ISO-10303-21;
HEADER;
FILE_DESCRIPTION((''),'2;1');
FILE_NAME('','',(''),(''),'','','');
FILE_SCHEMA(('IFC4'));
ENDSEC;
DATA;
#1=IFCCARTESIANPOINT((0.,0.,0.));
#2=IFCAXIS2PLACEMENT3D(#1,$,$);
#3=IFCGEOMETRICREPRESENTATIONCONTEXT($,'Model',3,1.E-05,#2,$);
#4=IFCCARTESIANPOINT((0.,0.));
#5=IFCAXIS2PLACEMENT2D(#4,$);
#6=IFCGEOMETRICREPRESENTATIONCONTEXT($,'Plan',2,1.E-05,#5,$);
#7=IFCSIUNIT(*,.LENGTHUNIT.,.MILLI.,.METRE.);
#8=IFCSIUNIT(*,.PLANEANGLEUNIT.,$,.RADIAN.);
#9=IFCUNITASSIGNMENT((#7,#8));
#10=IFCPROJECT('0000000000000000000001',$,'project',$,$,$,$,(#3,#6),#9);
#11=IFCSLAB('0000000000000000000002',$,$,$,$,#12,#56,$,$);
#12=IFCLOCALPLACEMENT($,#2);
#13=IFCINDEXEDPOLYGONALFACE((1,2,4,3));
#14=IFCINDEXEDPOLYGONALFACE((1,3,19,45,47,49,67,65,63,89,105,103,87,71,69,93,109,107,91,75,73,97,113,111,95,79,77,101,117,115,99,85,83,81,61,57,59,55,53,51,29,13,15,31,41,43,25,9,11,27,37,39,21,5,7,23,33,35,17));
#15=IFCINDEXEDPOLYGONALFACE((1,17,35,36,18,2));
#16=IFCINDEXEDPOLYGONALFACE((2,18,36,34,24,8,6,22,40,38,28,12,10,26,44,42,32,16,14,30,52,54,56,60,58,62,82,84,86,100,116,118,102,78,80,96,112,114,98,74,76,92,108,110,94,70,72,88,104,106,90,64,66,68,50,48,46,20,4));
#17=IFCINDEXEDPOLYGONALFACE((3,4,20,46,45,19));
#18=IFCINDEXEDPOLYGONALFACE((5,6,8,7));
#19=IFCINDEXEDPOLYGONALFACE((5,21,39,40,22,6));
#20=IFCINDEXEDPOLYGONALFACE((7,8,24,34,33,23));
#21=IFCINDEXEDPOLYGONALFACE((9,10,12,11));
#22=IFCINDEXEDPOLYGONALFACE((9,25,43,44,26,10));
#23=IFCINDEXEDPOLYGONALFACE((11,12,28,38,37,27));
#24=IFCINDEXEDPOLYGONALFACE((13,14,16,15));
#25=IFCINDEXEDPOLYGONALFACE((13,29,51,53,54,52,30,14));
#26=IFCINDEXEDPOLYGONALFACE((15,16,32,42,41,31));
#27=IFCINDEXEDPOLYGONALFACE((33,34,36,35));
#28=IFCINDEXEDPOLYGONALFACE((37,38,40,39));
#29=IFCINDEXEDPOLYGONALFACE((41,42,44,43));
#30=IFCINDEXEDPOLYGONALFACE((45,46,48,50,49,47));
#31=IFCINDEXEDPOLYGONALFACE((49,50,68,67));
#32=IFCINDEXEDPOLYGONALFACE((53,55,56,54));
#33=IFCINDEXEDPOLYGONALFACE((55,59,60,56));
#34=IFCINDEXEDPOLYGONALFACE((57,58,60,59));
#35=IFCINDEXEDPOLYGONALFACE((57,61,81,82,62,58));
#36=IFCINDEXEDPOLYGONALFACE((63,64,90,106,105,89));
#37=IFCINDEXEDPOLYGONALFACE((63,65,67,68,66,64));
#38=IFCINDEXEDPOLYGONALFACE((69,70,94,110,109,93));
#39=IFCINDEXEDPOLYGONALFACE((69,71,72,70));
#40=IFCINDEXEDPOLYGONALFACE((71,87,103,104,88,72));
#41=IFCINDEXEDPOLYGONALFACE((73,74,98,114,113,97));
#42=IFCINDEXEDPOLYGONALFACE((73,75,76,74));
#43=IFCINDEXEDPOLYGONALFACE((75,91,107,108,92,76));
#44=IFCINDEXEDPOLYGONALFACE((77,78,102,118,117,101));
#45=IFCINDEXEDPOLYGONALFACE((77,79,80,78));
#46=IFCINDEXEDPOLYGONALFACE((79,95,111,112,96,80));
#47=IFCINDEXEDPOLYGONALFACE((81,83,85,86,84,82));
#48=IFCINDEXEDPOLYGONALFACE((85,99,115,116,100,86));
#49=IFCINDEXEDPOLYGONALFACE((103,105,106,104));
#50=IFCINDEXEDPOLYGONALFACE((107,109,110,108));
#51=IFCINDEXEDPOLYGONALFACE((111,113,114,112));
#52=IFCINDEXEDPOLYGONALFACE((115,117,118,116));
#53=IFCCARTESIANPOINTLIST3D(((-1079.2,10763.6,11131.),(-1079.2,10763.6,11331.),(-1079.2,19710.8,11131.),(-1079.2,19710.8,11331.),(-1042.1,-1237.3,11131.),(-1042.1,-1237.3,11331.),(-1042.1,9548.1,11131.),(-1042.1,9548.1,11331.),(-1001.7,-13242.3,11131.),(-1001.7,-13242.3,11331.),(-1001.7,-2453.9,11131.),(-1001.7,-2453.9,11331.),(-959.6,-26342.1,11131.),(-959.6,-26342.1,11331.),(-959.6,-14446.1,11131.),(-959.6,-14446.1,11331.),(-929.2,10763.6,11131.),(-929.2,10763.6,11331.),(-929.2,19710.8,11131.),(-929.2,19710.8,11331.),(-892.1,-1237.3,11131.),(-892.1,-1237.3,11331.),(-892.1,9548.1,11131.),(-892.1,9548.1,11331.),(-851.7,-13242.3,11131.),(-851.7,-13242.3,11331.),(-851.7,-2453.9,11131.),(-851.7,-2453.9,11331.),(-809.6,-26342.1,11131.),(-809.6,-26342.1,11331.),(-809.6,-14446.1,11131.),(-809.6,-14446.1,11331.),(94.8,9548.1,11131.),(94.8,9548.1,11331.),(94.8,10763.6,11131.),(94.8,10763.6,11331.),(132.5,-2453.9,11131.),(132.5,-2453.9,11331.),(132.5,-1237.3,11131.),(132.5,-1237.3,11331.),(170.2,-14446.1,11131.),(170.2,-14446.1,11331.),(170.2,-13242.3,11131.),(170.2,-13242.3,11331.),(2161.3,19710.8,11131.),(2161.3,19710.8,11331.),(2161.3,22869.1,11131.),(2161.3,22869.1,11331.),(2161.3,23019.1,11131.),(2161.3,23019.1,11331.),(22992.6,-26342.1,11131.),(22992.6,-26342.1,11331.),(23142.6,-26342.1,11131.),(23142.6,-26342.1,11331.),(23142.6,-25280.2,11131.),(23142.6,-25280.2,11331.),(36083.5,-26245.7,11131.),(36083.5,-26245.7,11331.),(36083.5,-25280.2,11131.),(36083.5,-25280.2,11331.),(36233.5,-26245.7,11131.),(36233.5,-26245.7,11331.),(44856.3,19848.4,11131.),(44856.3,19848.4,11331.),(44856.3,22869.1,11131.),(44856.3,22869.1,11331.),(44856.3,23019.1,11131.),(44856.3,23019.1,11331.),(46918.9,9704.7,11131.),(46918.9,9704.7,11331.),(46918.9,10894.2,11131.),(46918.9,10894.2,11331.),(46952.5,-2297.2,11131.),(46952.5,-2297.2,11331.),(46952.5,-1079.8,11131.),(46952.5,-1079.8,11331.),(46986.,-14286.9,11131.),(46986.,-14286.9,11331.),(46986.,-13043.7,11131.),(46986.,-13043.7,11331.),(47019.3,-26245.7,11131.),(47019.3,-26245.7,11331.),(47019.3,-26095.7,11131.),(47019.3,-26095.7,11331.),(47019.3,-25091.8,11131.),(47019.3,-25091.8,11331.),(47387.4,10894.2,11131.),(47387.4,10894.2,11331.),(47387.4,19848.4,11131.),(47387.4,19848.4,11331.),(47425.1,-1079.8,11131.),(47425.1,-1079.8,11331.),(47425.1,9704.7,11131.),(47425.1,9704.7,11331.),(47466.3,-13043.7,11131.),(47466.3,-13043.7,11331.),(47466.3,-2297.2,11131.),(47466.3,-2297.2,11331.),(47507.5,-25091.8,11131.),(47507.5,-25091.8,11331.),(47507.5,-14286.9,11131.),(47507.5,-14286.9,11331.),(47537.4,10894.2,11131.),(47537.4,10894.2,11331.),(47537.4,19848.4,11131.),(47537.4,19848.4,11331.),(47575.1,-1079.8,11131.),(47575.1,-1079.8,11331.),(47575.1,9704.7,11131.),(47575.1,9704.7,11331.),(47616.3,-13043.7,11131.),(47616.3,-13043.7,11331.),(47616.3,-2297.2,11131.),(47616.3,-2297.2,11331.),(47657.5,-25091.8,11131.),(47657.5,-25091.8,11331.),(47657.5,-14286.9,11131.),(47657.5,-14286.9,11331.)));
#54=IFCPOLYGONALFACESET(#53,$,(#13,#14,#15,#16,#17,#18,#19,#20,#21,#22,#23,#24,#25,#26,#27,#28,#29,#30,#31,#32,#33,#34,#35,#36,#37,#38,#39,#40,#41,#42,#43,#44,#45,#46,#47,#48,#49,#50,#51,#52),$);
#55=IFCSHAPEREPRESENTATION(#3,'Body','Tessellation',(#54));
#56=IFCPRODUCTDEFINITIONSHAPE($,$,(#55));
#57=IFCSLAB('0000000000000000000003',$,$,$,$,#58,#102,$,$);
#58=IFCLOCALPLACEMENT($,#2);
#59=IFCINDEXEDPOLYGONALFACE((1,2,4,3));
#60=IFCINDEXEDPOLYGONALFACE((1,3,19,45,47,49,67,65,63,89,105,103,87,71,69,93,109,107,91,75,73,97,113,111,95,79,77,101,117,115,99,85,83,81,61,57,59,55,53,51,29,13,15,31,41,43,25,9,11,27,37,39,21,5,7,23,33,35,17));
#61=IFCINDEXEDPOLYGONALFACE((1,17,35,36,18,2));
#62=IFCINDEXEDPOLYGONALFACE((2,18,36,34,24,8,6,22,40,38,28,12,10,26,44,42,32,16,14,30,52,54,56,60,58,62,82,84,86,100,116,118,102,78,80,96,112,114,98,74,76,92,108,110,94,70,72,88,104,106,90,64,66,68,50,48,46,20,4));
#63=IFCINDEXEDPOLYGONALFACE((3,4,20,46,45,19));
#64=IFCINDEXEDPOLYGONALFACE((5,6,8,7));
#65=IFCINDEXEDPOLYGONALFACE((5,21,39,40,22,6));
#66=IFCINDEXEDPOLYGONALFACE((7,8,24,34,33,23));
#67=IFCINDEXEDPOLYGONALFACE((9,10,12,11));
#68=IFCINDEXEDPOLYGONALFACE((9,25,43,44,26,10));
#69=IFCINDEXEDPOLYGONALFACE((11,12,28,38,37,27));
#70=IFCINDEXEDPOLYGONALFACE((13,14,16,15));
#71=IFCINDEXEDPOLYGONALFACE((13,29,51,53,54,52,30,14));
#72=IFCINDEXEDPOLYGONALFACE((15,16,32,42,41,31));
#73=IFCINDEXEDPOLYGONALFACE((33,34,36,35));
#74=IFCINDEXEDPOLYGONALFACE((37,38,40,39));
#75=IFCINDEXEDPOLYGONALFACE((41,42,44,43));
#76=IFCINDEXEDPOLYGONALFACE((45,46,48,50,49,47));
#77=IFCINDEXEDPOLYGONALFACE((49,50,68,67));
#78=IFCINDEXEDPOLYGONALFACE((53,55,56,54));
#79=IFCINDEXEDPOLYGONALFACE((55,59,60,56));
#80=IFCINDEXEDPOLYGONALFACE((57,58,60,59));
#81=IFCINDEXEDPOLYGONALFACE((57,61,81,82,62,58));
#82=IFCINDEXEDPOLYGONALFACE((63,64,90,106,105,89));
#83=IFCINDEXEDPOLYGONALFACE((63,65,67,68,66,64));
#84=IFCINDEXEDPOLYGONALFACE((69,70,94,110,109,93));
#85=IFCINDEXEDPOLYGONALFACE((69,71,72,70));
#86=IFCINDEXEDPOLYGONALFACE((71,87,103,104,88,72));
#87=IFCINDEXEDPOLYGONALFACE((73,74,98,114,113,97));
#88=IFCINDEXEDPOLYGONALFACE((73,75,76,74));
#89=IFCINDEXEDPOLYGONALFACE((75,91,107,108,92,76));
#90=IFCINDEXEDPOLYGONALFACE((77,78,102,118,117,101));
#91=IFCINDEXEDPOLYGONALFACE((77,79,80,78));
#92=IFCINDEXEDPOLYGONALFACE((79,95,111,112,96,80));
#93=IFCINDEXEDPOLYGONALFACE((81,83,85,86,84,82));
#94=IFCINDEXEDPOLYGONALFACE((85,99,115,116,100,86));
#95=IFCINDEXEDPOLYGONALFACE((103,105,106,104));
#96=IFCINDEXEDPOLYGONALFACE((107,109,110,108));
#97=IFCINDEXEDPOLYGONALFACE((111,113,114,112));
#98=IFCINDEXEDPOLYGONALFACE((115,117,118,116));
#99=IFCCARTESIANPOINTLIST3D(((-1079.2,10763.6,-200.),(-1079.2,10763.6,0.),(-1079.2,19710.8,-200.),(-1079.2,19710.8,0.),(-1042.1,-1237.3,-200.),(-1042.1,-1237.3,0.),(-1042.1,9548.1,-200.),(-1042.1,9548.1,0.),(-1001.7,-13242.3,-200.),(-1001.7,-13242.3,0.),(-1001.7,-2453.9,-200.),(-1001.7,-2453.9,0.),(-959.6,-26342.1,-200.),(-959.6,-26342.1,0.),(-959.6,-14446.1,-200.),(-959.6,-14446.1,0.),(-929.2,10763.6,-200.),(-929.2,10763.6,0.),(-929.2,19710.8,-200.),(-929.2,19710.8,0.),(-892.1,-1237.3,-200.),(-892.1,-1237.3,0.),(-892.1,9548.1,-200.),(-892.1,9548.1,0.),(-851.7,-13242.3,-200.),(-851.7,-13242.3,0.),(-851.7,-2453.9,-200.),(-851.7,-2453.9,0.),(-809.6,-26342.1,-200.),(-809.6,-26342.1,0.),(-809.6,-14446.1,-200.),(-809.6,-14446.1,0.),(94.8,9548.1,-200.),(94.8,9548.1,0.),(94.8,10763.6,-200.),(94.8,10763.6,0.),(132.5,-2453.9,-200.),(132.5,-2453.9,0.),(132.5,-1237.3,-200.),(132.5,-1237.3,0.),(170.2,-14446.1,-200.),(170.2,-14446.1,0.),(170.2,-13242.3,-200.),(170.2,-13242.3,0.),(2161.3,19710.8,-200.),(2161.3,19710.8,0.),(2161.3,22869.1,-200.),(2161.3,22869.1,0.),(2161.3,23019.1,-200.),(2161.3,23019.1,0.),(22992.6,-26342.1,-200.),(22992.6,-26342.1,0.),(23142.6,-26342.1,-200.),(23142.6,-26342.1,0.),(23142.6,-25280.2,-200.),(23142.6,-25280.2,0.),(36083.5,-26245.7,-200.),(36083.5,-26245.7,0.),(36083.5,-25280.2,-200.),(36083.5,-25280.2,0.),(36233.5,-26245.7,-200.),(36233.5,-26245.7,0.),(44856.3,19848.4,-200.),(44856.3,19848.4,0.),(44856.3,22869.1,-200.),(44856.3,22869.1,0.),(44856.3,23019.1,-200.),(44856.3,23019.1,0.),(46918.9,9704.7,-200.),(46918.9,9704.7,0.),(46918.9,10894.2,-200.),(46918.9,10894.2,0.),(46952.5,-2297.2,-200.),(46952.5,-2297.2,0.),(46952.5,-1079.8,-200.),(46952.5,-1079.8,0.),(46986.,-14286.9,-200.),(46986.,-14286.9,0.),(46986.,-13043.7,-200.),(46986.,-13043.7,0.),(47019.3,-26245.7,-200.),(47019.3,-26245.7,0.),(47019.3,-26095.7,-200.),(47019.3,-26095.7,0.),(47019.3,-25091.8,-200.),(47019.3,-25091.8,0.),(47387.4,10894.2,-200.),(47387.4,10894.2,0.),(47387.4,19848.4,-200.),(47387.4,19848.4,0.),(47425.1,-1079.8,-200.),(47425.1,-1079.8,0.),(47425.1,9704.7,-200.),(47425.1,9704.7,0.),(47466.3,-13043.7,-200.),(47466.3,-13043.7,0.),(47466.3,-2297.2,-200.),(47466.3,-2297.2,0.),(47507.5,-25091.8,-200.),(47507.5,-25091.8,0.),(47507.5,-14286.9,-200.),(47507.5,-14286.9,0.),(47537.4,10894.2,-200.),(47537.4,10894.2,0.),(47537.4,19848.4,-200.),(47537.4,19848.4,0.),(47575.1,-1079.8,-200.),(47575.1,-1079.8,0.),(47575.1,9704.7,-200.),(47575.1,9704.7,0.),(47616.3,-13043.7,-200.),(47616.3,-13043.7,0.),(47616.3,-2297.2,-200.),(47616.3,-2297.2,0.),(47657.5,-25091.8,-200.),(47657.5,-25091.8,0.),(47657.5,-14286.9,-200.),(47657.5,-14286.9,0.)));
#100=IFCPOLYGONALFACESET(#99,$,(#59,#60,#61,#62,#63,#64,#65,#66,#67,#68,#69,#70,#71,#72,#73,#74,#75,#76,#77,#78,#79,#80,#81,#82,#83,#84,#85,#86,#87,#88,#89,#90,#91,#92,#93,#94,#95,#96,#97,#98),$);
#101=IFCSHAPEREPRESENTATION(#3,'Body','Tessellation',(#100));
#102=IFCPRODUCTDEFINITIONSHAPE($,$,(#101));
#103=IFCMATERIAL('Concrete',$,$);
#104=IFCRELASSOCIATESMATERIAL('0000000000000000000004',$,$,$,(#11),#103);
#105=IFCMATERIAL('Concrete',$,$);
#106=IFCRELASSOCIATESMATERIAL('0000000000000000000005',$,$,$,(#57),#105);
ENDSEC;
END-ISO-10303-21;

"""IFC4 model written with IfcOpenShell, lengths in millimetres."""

from ifc_helpers import new_model, si_unit, frame, origin, origin_2d, place, context, project, polyline, outline, extrude, material, element, save


model = new_model("IFC4")

# Units and contexts
model_context = context("Model", 3, precision=1e-05, world=origin())
plan_context = context("Plan", 2, precision=1e-05, world=origin_2d())
ifc_project = project(units=[si_unit("LENGTHUNIT", "METRE", prefix="MILLI"), si_unit("PLANEANGLEUNIT", "RADIAN")], contexts=[model_context, plan_context])

# Slabs
ifc_material_1 = material(Name="Concrete")
placement = place(None, origin())
element("IfcSlab", 1, at=placement, material=ifc_material_1, context=model_context, shape_type="SweptSolid", body=[
    extrude(outline(polyline([(46986.0, -14286.9), (46986.0, -13043.7), (47466.3, -13043.7), (47616.3, -13043.7), (47616.3, -2297.2), (47466.3, -2297.2), (46952.5, -2297.2), (46952.5, -1079.8), (47425.1, -1079.8), (47575.1, -1079.8), (47575.1, 9704.7), (47425.1, 9704.7), (46918.9, 9704.7), (46918.9, 10894.2), (47387.4, 10894.2), (47537.4, 10894.2), (47537.4, 19848.4), (47387.4, 19848.4), (44856.3, 19848.4), (44856.3, 22869.1), (44856.3, 23019.1), (2161.3, 23019.1), (2161.3, 22869.1), (2161.3, 19710.8), (-929.2, 19710.8), (-1079.2, 19710.8), (-1079.2, 10763.6), (-929.2, 10763.6), (94.8, 10763.6), (94.8, 9548.1), (-892.1, 9548.1), (-1042.1, 9548.1), (-1042.1, -1237.3), (-892.1, -1237.3), (132.5, -1237.3), (132.5, -2453.9), (-851.7, -2453.9), (-1001.7, -2453.9), (-1001.7, -13242.3), (-851.7, -13242.3), (170.2, -13242.3), (170.2, -14446.1), (-809.6, -14446.1), (-959.6, -14446.1), (-959.6, -26342.1), (-809.6, -26342.1), (22992.6, -26342.1), (23142.6, -26342.1), (23142.6, -25280.2), (36083.5, -25280.2), (36083.5, -26245.7), (36233.5, -26245.7), (47019.3, -26245.7), (47019.3, -26095.7), (47019.3, -25091.8), (47507.5, -25091.8), (47657.5, -25091.8), (47657.5, -14286.9), (47507.5, -14286.9), (46986.0, -14286.9)])), frame((0.0, 0.0, 11131.0), z_axis=(0.0, 0.0, 1000.0), x_axis=(1000.0, 0.0, 0.0)), (0.0, 0.0, 1.0), 200.0),
])
ifc_material_2 = material(Name="Concrete")
element("IfcSlab", 2, at=placement, material=ifc_material_2, context=model_context, shape_type="SweptSolid", body=[
    extrude(outline(polyline([(46986.0, -14286.9), (46986.0, -13043.7), (47466.3, -13043.7), (47616.3, -13043.7), (47616.3, -2297.2), (47466.3, -2297.2), (46952.5, -2297.2), (46952.5, -1079.8), (47425.1, -1079.8), (47575.1, -1079.8), (47575.1, 9704.7), (47425.1, 9704.7), (46918.9, 9704.7), (46918.9, 10894.2), (47387.4, 10894.2), (47537.4, 10894.2), (47537.4, 19848.4), (47387.4, 19848.4), (44856.3, 19848.4), (44856.3, 22869.1), (44856.3, 23019.1), (2161.3, 23019.1), (2161.3, 22869.1), (2161.3, 19710.8), (-929.2, 19710.8), (-1079.2, 19710.8), (-1079.2, 10763.6), (-929.2, 10763.6), (94.8, 10763.6), (94.8, 9548.1), (-892.1, 9548.1), (-1042.1, 9548.1), (-1042.1, -1237.3), (-892.1, -1237.3), (132.5, -1237.3), (132.5, -2453.9), (-851.7, -2453.9), (-1001.7, -2453.9), (-1001.7, -13242.3), (-851.7, -13242.3), (170.2, -13242.3), (170.2, -14446.1), (-809.6, -14446.1), (-959.6, -14446.1), (-959.6, -26342.1), (-809.6, -26342.1), (22992.6, -26342.1), (23142.6, -26342.1), (23142.6, -25280.2), (36083.5, -25280.2), (36083.5, -26245.7), (36233.5, -26245.7), (47019.3, -26245.7), (47019.3, -26095.7), (47019.3, -25091.8), (47507.5, -25091.8), (47657.5, -25091.8), (47657.5, -14286.9), (47507.5, -14286.9), (46986.0, -14286.9)])), frame((0.0, 0.0, -200.0), z_axis=(0.0, 0.0, 1000.0), x_axis=(1000.0, 0.0, 0.0)), (0.0, 0.0, 1.0), 200.0),
])

save(model, "model.ifc")
